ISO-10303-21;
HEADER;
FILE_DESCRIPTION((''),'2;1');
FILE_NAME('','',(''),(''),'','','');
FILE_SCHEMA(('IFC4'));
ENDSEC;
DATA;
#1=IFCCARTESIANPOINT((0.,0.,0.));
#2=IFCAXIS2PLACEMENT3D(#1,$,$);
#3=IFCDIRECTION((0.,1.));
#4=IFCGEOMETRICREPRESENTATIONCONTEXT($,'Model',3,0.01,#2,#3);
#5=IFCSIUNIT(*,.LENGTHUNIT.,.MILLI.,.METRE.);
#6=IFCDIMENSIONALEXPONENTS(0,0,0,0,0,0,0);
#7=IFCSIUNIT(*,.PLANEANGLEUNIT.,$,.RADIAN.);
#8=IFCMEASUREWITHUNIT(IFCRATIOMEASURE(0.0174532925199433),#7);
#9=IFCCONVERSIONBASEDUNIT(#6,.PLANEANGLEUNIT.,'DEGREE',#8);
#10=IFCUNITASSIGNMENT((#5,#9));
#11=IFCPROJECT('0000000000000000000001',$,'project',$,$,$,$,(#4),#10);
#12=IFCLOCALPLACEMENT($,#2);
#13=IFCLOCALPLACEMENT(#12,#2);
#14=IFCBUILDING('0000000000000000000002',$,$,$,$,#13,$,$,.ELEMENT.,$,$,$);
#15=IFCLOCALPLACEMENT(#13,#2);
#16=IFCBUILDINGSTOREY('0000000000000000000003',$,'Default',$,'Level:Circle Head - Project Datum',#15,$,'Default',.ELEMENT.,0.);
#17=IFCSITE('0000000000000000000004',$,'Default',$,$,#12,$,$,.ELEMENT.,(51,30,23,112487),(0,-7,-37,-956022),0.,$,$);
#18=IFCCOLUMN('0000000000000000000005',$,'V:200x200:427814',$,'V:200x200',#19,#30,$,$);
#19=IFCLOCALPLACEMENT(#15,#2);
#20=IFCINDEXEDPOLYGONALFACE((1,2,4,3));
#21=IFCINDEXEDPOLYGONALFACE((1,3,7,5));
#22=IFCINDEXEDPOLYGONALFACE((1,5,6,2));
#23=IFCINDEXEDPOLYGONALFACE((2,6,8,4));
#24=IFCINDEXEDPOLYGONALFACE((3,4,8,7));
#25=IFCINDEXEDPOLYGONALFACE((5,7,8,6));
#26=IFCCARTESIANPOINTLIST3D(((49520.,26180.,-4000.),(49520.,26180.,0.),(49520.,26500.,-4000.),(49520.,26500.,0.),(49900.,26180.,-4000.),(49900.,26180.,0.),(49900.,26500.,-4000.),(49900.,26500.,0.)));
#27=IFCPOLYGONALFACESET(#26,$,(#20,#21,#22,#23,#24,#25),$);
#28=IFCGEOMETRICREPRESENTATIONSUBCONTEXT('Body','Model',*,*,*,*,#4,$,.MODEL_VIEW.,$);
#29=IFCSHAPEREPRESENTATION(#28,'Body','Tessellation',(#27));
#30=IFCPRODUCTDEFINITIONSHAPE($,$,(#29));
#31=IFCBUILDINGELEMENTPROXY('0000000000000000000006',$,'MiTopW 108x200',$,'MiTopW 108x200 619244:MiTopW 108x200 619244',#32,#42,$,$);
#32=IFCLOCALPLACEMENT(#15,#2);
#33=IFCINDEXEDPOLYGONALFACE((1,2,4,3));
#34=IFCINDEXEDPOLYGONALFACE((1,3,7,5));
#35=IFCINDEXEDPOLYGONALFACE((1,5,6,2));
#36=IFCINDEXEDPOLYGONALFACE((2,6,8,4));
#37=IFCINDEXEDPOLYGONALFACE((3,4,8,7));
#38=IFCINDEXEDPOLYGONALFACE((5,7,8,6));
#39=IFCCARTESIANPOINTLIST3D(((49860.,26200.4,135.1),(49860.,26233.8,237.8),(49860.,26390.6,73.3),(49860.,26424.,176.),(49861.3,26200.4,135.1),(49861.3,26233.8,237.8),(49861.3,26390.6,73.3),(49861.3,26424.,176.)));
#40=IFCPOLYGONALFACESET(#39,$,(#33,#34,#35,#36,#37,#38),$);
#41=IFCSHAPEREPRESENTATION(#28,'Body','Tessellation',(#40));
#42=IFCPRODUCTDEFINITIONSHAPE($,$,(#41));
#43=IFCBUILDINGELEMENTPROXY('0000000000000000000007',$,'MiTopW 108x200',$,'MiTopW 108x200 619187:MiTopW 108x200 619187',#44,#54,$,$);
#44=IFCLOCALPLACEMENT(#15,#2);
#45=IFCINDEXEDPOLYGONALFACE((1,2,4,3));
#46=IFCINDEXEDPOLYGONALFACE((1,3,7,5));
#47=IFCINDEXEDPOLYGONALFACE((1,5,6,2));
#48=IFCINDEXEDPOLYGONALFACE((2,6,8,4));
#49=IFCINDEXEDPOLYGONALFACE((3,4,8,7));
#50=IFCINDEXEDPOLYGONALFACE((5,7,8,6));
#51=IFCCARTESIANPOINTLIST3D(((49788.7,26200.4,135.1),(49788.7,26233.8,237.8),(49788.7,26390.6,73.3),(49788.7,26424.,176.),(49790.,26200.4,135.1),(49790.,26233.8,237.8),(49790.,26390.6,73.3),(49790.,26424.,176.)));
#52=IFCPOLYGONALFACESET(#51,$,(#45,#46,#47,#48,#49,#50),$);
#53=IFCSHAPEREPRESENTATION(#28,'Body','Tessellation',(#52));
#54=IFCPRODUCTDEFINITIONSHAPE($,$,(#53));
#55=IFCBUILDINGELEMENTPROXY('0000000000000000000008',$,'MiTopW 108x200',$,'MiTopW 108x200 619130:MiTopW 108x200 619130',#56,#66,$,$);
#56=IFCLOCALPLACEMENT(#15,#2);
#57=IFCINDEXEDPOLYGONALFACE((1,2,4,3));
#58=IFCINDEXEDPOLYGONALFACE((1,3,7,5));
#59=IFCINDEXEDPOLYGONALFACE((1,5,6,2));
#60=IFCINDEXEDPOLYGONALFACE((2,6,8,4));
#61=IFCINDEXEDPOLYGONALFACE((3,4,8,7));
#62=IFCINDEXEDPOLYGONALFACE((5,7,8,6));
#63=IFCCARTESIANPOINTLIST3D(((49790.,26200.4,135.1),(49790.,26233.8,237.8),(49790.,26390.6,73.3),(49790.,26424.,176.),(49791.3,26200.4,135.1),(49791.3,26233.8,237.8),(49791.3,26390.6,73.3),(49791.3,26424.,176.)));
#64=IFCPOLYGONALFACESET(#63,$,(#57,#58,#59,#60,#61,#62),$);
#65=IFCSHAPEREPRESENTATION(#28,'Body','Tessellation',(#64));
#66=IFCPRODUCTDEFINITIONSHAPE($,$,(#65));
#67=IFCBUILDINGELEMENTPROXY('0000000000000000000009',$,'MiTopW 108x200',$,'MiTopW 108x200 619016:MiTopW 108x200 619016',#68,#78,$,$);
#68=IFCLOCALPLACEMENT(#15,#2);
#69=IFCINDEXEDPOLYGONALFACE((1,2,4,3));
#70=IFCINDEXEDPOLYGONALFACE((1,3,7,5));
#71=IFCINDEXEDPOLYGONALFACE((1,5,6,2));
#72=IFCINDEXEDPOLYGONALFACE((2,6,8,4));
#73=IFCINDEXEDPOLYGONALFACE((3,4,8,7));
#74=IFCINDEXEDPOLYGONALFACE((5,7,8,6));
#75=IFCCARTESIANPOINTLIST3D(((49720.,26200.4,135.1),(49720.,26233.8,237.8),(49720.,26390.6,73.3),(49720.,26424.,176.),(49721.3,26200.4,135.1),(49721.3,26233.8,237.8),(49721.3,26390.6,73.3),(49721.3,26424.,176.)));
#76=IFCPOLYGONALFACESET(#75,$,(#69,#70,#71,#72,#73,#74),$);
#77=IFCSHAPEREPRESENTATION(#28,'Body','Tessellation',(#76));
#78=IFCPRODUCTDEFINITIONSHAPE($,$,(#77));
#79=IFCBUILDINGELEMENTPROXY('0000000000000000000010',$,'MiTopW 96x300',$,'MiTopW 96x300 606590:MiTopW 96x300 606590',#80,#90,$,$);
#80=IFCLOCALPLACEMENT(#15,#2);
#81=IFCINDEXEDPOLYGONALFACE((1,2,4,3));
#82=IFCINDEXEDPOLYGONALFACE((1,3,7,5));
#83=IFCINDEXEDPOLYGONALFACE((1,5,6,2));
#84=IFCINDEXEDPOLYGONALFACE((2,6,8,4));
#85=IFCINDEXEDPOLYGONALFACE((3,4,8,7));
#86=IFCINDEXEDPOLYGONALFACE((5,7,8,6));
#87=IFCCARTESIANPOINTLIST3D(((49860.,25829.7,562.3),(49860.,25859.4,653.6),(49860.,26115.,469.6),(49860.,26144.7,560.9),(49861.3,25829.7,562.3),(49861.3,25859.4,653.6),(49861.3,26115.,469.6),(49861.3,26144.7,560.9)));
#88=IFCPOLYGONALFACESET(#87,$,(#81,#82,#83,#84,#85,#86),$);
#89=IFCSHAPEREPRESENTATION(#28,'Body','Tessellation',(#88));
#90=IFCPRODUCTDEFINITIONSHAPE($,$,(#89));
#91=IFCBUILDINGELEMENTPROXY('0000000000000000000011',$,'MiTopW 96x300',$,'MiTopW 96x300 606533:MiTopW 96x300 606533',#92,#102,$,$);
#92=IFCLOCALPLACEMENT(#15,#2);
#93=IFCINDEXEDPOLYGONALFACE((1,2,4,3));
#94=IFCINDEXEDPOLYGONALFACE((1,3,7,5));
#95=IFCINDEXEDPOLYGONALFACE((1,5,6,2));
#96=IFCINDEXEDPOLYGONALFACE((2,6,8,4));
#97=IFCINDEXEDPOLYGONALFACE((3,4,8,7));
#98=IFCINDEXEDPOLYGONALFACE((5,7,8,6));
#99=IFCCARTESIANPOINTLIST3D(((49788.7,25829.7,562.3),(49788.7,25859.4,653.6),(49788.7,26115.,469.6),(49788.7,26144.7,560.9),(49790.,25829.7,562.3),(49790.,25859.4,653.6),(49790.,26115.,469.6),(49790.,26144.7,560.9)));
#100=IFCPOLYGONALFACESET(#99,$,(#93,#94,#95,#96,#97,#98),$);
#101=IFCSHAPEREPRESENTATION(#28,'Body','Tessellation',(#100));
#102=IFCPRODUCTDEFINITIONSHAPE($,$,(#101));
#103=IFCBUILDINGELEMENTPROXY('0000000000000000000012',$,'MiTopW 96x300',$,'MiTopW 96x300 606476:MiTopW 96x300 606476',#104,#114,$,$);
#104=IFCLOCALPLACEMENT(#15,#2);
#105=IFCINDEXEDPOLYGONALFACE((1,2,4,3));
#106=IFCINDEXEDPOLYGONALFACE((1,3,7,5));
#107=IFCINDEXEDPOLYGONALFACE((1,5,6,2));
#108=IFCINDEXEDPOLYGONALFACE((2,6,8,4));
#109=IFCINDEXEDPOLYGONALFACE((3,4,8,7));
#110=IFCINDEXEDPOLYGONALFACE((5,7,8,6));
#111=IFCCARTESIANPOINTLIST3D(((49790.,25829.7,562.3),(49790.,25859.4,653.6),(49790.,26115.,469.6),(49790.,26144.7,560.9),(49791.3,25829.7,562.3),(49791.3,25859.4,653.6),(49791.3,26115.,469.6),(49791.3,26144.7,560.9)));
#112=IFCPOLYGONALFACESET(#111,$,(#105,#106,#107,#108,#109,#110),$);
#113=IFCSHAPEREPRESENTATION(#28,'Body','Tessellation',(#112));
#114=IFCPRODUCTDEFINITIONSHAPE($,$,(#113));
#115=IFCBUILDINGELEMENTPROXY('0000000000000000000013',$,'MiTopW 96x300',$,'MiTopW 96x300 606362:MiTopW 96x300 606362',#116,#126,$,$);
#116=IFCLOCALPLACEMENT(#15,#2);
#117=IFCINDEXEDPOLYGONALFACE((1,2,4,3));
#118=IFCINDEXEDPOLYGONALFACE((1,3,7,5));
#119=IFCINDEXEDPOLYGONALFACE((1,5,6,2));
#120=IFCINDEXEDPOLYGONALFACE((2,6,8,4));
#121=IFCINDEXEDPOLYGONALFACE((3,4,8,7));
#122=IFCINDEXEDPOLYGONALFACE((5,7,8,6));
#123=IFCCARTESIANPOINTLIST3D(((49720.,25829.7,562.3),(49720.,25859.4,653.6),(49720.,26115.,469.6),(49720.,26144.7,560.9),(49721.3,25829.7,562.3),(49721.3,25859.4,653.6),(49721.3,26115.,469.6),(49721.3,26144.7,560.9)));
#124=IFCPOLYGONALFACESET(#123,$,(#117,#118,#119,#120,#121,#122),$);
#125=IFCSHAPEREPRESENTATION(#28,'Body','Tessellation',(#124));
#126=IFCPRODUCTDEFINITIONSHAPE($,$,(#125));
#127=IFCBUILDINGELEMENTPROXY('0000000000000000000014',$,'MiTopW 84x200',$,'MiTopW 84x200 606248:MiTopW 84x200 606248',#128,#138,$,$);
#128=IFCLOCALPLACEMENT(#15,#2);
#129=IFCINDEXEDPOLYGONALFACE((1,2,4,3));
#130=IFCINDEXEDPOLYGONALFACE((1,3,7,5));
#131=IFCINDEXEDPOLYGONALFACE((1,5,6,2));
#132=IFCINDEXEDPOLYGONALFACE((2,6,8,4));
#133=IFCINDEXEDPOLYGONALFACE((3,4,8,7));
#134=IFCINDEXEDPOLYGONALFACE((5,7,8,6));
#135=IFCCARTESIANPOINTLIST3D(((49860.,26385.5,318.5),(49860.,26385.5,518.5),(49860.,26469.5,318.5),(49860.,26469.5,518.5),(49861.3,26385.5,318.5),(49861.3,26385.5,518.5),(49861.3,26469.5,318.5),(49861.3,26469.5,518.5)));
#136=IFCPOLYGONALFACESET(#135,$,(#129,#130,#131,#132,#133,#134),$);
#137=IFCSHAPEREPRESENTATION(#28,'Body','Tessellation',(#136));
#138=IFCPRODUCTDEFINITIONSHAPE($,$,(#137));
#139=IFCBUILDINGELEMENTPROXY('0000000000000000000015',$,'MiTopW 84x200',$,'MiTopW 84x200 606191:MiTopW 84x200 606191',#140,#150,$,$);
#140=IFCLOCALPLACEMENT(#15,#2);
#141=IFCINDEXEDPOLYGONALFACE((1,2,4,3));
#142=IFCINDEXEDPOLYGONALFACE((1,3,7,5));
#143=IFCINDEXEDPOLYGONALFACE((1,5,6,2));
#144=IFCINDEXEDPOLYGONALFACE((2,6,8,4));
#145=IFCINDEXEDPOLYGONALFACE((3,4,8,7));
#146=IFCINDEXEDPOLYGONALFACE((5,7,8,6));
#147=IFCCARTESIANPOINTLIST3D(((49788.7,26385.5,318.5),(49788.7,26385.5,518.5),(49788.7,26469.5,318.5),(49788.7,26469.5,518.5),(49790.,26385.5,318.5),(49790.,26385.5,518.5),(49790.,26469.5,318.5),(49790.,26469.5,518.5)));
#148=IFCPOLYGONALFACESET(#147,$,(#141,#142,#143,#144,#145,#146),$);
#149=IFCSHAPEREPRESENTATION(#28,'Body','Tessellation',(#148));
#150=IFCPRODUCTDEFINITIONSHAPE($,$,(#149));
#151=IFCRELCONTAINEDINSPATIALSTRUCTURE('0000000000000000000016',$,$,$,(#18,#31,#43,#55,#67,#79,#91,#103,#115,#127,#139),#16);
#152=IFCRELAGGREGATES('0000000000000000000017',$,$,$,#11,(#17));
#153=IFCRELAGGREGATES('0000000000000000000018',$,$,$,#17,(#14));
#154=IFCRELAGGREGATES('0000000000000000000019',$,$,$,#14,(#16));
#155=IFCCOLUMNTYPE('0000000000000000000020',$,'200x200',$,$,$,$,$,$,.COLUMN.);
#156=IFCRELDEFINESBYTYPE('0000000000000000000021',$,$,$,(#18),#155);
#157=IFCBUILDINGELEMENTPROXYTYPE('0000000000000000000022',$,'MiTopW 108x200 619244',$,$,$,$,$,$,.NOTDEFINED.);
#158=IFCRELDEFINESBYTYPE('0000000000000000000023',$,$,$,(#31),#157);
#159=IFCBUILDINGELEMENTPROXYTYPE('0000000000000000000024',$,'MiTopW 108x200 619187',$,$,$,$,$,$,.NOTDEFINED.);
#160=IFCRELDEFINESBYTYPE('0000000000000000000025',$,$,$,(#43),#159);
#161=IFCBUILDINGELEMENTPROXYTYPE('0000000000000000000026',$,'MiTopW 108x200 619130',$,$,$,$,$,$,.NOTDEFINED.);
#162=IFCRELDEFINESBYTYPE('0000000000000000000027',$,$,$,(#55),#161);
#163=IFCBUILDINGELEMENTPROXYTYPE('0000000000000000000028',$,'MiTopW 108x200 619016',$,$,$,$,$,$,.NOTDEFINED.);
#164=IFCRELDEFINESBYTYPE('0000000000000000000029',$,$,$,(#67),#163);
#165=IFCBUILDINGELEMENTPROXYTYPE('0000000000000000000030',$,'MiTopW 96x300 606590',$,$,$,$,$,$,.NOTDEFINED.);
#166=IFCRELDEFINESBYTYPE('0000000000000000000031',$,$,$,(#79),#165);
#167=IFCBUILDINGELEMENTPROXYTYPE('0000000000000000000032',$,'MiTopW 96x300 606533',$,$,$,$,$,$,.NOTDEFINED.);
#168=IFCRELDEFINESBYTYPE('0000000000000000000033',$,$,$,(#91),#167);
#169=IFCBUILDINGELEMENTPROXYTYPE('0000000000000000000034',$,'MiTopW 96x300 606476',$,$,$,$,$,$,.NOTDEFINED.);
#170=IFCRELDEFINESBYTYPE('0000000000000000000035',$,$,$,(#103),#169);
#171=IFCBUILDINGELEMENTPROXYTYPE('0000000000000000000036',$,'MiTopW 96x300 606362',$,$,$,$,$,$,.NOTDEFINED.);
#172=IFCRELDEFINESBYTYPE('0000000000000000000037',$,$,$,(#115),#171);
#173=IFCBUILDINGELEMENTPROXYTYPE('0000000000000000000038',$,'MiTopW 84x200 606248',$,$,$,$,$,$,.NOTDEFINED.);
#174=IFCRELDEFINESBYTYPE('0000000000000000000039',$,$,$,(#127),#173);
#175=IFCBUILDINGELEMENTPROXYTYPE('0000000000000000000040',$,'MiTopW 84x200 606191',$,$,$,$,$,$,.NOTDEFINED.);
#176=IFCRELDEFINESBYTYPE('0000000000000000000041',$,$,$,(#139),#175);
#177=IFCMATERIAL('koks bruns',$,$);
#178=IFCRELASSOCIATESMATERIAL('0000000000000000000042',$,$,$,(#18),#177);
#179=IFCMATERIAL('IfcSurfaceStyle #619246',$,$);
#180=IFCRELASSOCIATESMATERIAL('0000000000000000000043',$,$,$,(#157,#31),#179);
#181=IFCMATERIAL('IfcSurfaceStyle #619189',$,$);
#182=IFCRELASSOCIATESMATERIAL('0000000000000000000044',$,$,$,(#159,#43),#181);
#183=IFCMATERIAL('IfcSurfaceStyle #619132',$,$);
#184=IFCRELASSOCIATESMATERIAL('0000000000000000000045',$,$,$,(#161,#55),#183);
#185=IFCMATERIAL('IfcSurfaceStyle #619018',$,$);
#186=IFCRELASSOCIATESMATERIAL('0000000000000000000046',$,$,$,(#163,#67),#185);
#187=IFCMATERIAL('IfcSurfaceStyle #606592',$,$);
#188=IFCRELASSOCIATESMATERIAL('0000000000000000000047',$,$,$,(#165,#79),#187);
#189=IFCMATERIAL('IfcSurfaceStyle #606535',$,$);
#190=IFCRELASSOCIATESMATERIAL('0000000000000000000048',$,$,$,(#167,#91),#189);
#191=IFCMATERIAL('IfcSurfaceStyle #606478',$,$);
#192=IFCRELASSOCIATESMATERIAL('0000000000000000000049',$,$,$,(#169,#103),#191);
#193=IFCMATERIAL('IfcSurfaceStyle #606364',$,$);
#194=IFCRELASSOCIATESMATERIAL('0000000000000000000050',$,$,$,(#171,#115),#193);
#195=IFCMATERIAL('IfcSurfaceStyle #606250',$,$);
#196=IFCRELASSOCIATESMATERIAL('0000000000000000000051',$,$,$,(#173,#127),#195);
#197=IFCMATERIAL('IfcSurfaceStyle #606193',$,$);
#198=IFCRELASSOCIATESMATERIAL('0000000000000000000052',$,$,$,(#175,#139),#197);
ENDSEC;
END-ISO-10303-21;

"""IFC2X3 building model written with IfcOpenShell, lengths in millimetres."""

from ifc_helpers import new_model, entity, si_unit, converted_unit, direction, frame, frame_2d, origin, origin_2d_with_axis, place, context, subcontext, project, spatial, polyline, rectangle, outline, extrude, source, transform, mapped, material, type_object, type_shapes, element, save


model = new_model("IFC2X3")

# Units and contexts
model_context = context("Model", 3, precision=0.01, world=origin(), true_north=direction((0.0, 1.0)))
body_context = subcontext(model_context, "Body", "Model", "MODEL_VIEW")
ifc_project = project(units=[si_unit("LENGTHUNIT", "METRE", prefix="MILLI"), converted_unit("PLANEANGLEUNIT", "DEGREE", entity("IfcRatioMeasure", 0.0174532925199433), si_unit("PLANEANGLEUNIT", "RADIAN"), dimensions=[0, 0, 0, 0, 0, 0, 0])], contexts=[model_context])

# Site, building, storey
site_placement = place(None, origin())
site = spatial("IfcSite", under=ifc_project, at=site_placement, Name="Default", CompositionType="ELEMENT", RefLatitude=(51, 30, 23, 112487), RefLongitude=(0, -7, -37, -956022), RefElevation=0.0)
building_placement = place(site_placement, origin())
building = spatial("IfcBuilding", under=site, at=building_placement, CompositionType="ELEMENT")
storey_placement = place(building_placement, origin())
storey = spatial("IfcBuildingStorey", under=building, at=storey_placement, Name="Default", ObjectType="Level:Circle Head - Project Datum", LongName="Default", CompositionType="ELEMENT", Elevation=0.0)

# Column
ifc_material_1 = material(Name="koks bruns")
column_type = type_object("IfcColumnType", Name="200x200", PredefinedType="COLUMN")
shared_shape_1 = source(origin(), body_context, "Body", "SweptSolid", [
    extrude(rectangle(XDim=380.0, YDim=320.0, at=origin_2d_with_axis()), frame((160.0, 300.0, -4000.0), z_axis=(0.0, 0.0, 1.0), x_axis=(0.0, -1.0, 0.0)), (0.0, 0.0, 1.0), 4000.0),
])
type_shapes(column_type, [shared_shape_1])
column_placement = place(storey_placement, frame((50010.0, 26180.0, 0.0), z_axis=(0.0, 0.0, 1.0), x_axis=(0.0, 1.0, 0.0)))
element("IfcColumn", 1, at=column_placement, inside=storey, type_object=column_type, material=ifc_material_1, Name="V:200x200:427814", ObjectType="V:200x200", context=body_context, shape_type="MappedRepresentation", body=[
    mapped(shared_shape_1, transform((0.0, 0.0, 0.0), scale=1.0)),
])

# Building element proxies
ifc_material_2 = material(Name="IfcSurfaceStyle #619246")
building_element_proxy_type_1 = type_object("IfcBuildingElementProxyType", Name="MiTopW 108x200 619244", PredefinedType="NOTDEFINED", material=ifc_material_2)
shared_shape_2 = source(origin(), body_context, "Body", "SweptSolid", [
    extrude(outline(polyline([(-100.0, -54.0), (100.0, -54.0), (100.0, 54.0), (-100.0, 54.0), (-100.0, -54.0)])), frame((100.0, 54.0, 0.0), z_axis=(0.0, 0.0, 1.0), x_axis=(-1.0, 0.0, 0.0)), (0.0, 0.0, 1.0), 1.3),
])
type_shapes(building_element_proxy_type_1, [shared_shape_2])
proxy_1_placement = place(building_placement, frame((49861.3, 26390.6, 73.3), z_axis=(-1.0, 0.0, 0.0), x_axis=(0.0, -0.951057, 0.309017)))
element("IfcBuildingElementProxy", 2, at=proxy_1_placement, inside=storey, type_object=building_element_proxy_type_1, material=ifc_material_2, Name="MiTopW 108x200", ObjectType="MiTopW 108x200 619244:MiTopW 108x200 619244", context=body_context, shape_type="MappedRepresentation", body=[
    mapped(shared_shape_2, transform((0.0, 0.0, 0.0), scale=1.0)),
])
ifc_material_3 = material(Name="IfcSurfaceStyle #619189")
building_element_proxy_type_2 = type_object("IfcBuildingElementProxyType", Name="MiTopW 108x200 619187", PredefinedType="NOTDEFINED", material=ifc_material_3)
shared_shape_3 = source(origin(), body_context, "Body", "SweptSolid", [
    extrude(outline(polyline([(-100.0, -54.0), (100.0, -54.0), (100.0, 54.0), (-100.0, 54.0), (-100.0, -54.0)])), frame((100.0, 54.0, 0.0), z_axis=(0.0, 0.0, 1.0), x_axis=(-1.0, 0.0, 0.0)), (0.0, 0.0, 1.0), 1.3),
])
type_shapes(building_element_proxy_type_2, [shared_shape_3])
proxy_2_placement = place(building_placement, frame((49790.0, 26390.6, 73.3), z_axis=(-1.0, 0.0, 0.0), x_axis=(0.0, -0.951057, 0.309017)))
element("IfcBuildingElementProxy", 3, at=proxy_2_placement, inside=storey, type_object=building_element_proxy_type_2, material=ifc_material_3, Name="MiTopW 108x200", ObjectType="MiTopW 108x200 619187:MiTopW 108x200 619187", context=body_context, shape_type="MappedRepresentation", body=[
    mapped(shared_shape_3, transform((0.0, 0.0, 0.0), scale=1.0)),
])
ifc_material_4 = material(Name="IfcSurfaceStyle #619132")
building_element_proxy_type_3 = type_object("IfcBuildingElementProxyType", Name="MiTopW 108x200 619130", PredefinedType="NOTDEFINED", material=ifc_material_4)
shared_shape_4 = source(origin(), body_context, "Body", "SweptSolid", [
    extrude(outline(polyline([(-100.0, -54.0), (100.0, -54.0), (100.0, 54.0), (-100.0, 54.0), (-100.0, -54.0)])), frame((100.0, 54.0, 0.0), z_axis=(0.0, 0.0, 1.0), x_axis=(-1.0, 0.0, 0.0)), (0.0, 0.0, 1.0), 1.3),
])
type_shapes(building_element_proxy_type_3, [shared_shape_4])
proxy_3_placement = place(building_placement, frame((49791.3, 26390.6, 73.3), z_axis=(-1.0, 0.0, 0.0), x_axis=(0.0, -0.951057, 0.309017)))
element("IfcBuildingElementProxy", 4, at=proxy_3_placement, inside=storey, type_object=building_element_proxy_type_3, material=ifc_material_4, Name="MiTopW 108x200", ObjectType="MiTopW 108x200 619130:MiTopW 108x200 619130", context=body_context, shape_type="MappedRepresentation", body=[
    mapped(shared_shape_4, transform((0.0, 0.0, 0.0), scale=1.0)),
])
ifc_material_5 = material(Name="IfcSurfaceStyle #619018")
building_element_proxy_type_4 = type_object("IfcBuildingElementProxyType", Name="MiTopW 108x200 619016", PredefinedType="NOTDEFINED", material=ifc_material_5)
shared_shape_5 = source(origin(), body_context, "Body", "SweptSolid", [
    extrude(outline(polyline([(-100.0, -54.0), (100.0, -54.0), (100.0, 54.0), (-100.0, 54.0), (-100.0, -54.0)])), frame((100.0, 54.0, 0.0), z_axis=(0.0, 0.0, 1.0), x_axis=(-1.0, 0.0, 0.0)), (0.0, 0.0, 1.0), 1.3),
])
type_shapes(building_element_proxy_type_4, [shared_shape_5])
proxy_4_placement = place(building_placement, frame((49721.3, 26390.6, 73.3), z_axis=(-1.0, 0.0, 0.0), x_axis=(0.0, -0.951057, 0.309017)))
element("IfcBuildingElementProxy", 5, at=proxy_4_placement, inside=storey, type_object=building_element_proxy_type_4, material=ifc_material_5, Name="MiTopW 108x200", ObjectType="MiTopW 108x200 619016:MiTopW 108x200 619016", context=body_context, shape_type="MappedRepresentation", body=[
    mapped(shared_shape_5, transform((0.0, 0.0, 0.0), scale=1.0)),
])
ifc_material_6 = material(Name="IfcSurfaceStyle #606592")
building_element_proxy_type_5 = type_object("IfcBuildingElementProxyType", Name="MiTopW 96x300 606590", PredefinedType="NOTDEFINED", material=ifc_material_6)
shared_shape_6 = source(origin(), body_context, "Body", "SweptSolid", [
    extrude(outline(polyline([(-150.0, -48.0), (150.0, -48.0), (150.0, 48.0), (-150.0, 48.0), (-150.0, -48.0)])), frame((150.0, 48.0, 0.0), z_axis=(0.0, 0.0, 1.0), x_axis=(-1.0, 0.0, 0.0)), (0.0, 0.0, 1.0), 1.3),
])
type_shapes(building_element_proxy_type_5, [shared_shape_6])
proxy_5_placement = place(building_placement, frame((49861.3, 26115.0, 469.6), z_axis=(-1.0, 0.0, 0.0), x_axis=(0.0, -0.951057, 0.309017)))
element("IfcBuildingElementProxy", 6, at=proxy_5_placement, inside=storey, type_object=building_element_proxy_type_5, material=ifc_material_6, Name="MiTopW 96x300", ObjectType="MiTopW 96x300 606590:MiTopW 96x300 606590", context=body_context, shape_type="MappedRepresentation", body=[
    mapped(shared_shape_6, transform((0.0, 0.0, 0.0), scale=1.0)),
])
ifc_material_7 = material(Name="IfcSurfaceStyle #606535")
building_element_proxy_type_6 = type_object("IfcBuildingElementProxyType", Name="MiTopW 96x300 606533", PredefinedType="NOTDEFINED", material=ifc_material_7)
shared_shape_7 = source(origin(), body_context, "Body", "SweptSolid", [
    extrude(outline(polyline([(-150.0, -48.0), (150.0, -48.0), (150.0, 48.0), (-150.0, 48.0), (-150.0, -48.0)])), frame((150.0, 48.0, 0.0), z_axis=(0.0, 0.0, 1.0), x_axis=(-1.0, 0.0, 0.0)), (0.0, 0.0, 1.0), 1.3),
])
type_shapes(building_element_proxy_type_6, [shared_shape_7])
proxy_6_placement = place(building_placement, frame((49790.0, 26115.0, 469.6), z_axis=(-1.0, 0.0, 0.0), x_axis=(0.0, -0.951057, 0.309017)))
element("IfcBuildingElementProxy", 7, at=proxy_6_placement, inside=storey, type_object=building_element_proxy_type_6, material=ifc_material_7, Name="MiTopW 96x300", ObjectType="MiTopW 96x300 606533:MiTopW 96x300 606533", context=body_context, shape_type="MappedRepresentation", body=[
    mapped(shared_shape_7, transform((0.0, 0.0, 0.0), scale=1.0)),
])
ifc_material_8 = material(Name="IfcSurfaceStyle #606478")
building_element_proxy_type_7 = type_object("IfcBuildingElementProxyType", Name="MiTopW 96x300 606476", PredefinedType="NOTDEFINED", material=ifc_material_8)
shared_shape_8 = source(origin(), body_context, "Body", "SweptSolid", [
    extrude(outline(polyline([(-150.0, -48.0), (150.0, -48.0), (150.0, 48.0), (-150.0, 48.0), (-150.0, -48.0)])), frame((150.0, 48.0, 0.0), z_axis=(0.0, 0.0, 1.0), x_axis=(-1.0, 0.0, 0.0)), (0.0, 0.0, 1.0), 1.3),
])
type_shapes(building_element_proxy_type_7, [shared_shape_8])
proxy_7_placement = place(building_placement, frame((49791.3, 26115.0, 469.6), z_axis=(-1.0, 0.0, 0.0), x_axis=(0.0, -0.951057, 0.309017)))
element("IfcBuildingElementProxy", 8, at=proxy_7_placement, inside=storey, type_object=building_element_proxy_type_7, material=ifc_material_8, Name="MiTopW 96x300", ObjectType="MiTopW 96x300 606476:MiTopW 96x300 606476", context=body_context, shape_type="MappedRepresentation", body=[
    mapped(shared_shape_8, transform((0.0, 0.0, 0.0), scale=1.0)),
])
ifc_material_9 = material(Name="IfcSurfaceStyle #606364")
building_element_proxy_type_8 = type_object("IfcBuildingElementProxyType", Name="MiTopW 96x300 606362", PredefinedType="NOTDEFINED", material=ifc_material_9)
shared_shape_9 = source(origin(), body_context, "Body", "SweptSolid", [
    extrude(outline(polyline([(-150.0, -48.0), (150.0, -48.0), (150.0, 48.0), (-150.0, 48.0), (-150.0, -48.0)])), frame((150.0, 48.0, 0.0), z_axis=(0.0, 0.0, 1.0), x_axis=(-1.0, 0.0, 0.0)), (0.0, 0.0, 1.0), 1.3),
])
type_shapes(building_element_proxy_type_8, [shared_shape_9])
proxy_8_placement = place(building_placement, frame((49721.3, 26115.0, 469.6), z_axis=(-1.0, 0.0, 0.0), x_axis=(0.0, -0.951057, 0.309017)))
element("IfcBuildingElementProxy", 9, at=proxy_8_placement, inside=storey, type_object=building_element_proxy_type_8, material=ifc_material_9, Name="MiTopW 96x300", ObjectType="MiTopW 96x300 606362:MiTopW 96x300 606362", context=body_context, shape_type="MappedRepresentation", body=[
    mapped(shared_shape_9, transform((0.0, 0.0, 0.0), scale=1.0)),
])
ifc_material_10 = material(Name="IfcSurfaceStyle #606250")
building_element_proxy_type_9 = type_object("IfcBuildingElementProxyType", Name="MiTopW 84x200 606248", PredefinedType="NOTDEFINED", material=ifc_material_10)
shared_shape_10 = source(origin(), body_context, "Body", "SweptSolid", [
    extrude(rectangle(XDim=200.0, YDim=84.0, at=frame_2d((0.0, 0.0), x_axis=(1.0, 0.0))), frame((100.0, 42.0, 0.0), z_axis=(0.0, 0.0, 1.0), x_axis=(-1.0, 0.0, 0.0)), (0.0, 0.0, 1.0), 1.3),
])
type_shapes(building_element_proxy_type_9, [shared_shape_10])
proxy_9_placement = place(building_placement, frame((49861.3, 26469.5, 518.5), z_axis=(-1.0, 0.0, 0.0), x_axis=(0.0, 0.0, -1.0)))
element("IfcBuildingElementProxy", 10, at=proxy_9_placement, inside=storey, type_object=building_element_proxy_type_9, material=ifc_material_10, Name="MiTopW 84x200", ObjectType="MiTopW 84x200 606248:MiTopW 84x200 606248", context=body_context, shape_type="MappedRepresentation", body=[
    mapped(shared_shape_10, transform((0.0, 0.0, 0.0), scale=1.0)),
])
ifc_material_11 = material(Name="IfcSurfaceStyle #606193")
building_element_proxy_type_10 = type_object("IfcBuildingElementProxyType", Name="MiTopW 84x200 606191", PredefinedType="NOTDEFINED", material=ifc_material_11)
shared_shape_11 = source(origin(), body_context, "Body", "SweptSolid", [
    extrude(rectangle(XDim=200.0, YDim=84.0, at=frame_2d((0.0, 0.0), x_axis=(1.0, 0.0))), frame((100.0, 42.0, 0.0), z_axis=(0.0, 0.0, 1.0), x_axis=(-1.0, 0.0, 0.0)), (0.0, 0.0, 1.0), 1.3),
])
type_shapes(building_element_proxy_type_10, [shared_shape_11])
proxy_10_placement = place(building_placement, frame((49790.0, 26469.5, 518.5), z_axis=(-1.0, 0.0, 0.0), x_axis=(0.0, 0.0, -1.0)))
element("IfcBuildingElementProxy", 11, at=proxy_10_placement, inside=storey, type_object=building_element_proxy_type_10, material=ifc_material_11, Name="MiTopW 84x200", ObjectType="MiTopW 84x200 606191:MiTopW 84x200 606191", context=body_context, shape_type="MappedRepresentation", body=[
    mapped(shared_shape_11, transform((0.0, 0.0, 0.0), scale=1.0)),
])

save(model, "model.ifc")
